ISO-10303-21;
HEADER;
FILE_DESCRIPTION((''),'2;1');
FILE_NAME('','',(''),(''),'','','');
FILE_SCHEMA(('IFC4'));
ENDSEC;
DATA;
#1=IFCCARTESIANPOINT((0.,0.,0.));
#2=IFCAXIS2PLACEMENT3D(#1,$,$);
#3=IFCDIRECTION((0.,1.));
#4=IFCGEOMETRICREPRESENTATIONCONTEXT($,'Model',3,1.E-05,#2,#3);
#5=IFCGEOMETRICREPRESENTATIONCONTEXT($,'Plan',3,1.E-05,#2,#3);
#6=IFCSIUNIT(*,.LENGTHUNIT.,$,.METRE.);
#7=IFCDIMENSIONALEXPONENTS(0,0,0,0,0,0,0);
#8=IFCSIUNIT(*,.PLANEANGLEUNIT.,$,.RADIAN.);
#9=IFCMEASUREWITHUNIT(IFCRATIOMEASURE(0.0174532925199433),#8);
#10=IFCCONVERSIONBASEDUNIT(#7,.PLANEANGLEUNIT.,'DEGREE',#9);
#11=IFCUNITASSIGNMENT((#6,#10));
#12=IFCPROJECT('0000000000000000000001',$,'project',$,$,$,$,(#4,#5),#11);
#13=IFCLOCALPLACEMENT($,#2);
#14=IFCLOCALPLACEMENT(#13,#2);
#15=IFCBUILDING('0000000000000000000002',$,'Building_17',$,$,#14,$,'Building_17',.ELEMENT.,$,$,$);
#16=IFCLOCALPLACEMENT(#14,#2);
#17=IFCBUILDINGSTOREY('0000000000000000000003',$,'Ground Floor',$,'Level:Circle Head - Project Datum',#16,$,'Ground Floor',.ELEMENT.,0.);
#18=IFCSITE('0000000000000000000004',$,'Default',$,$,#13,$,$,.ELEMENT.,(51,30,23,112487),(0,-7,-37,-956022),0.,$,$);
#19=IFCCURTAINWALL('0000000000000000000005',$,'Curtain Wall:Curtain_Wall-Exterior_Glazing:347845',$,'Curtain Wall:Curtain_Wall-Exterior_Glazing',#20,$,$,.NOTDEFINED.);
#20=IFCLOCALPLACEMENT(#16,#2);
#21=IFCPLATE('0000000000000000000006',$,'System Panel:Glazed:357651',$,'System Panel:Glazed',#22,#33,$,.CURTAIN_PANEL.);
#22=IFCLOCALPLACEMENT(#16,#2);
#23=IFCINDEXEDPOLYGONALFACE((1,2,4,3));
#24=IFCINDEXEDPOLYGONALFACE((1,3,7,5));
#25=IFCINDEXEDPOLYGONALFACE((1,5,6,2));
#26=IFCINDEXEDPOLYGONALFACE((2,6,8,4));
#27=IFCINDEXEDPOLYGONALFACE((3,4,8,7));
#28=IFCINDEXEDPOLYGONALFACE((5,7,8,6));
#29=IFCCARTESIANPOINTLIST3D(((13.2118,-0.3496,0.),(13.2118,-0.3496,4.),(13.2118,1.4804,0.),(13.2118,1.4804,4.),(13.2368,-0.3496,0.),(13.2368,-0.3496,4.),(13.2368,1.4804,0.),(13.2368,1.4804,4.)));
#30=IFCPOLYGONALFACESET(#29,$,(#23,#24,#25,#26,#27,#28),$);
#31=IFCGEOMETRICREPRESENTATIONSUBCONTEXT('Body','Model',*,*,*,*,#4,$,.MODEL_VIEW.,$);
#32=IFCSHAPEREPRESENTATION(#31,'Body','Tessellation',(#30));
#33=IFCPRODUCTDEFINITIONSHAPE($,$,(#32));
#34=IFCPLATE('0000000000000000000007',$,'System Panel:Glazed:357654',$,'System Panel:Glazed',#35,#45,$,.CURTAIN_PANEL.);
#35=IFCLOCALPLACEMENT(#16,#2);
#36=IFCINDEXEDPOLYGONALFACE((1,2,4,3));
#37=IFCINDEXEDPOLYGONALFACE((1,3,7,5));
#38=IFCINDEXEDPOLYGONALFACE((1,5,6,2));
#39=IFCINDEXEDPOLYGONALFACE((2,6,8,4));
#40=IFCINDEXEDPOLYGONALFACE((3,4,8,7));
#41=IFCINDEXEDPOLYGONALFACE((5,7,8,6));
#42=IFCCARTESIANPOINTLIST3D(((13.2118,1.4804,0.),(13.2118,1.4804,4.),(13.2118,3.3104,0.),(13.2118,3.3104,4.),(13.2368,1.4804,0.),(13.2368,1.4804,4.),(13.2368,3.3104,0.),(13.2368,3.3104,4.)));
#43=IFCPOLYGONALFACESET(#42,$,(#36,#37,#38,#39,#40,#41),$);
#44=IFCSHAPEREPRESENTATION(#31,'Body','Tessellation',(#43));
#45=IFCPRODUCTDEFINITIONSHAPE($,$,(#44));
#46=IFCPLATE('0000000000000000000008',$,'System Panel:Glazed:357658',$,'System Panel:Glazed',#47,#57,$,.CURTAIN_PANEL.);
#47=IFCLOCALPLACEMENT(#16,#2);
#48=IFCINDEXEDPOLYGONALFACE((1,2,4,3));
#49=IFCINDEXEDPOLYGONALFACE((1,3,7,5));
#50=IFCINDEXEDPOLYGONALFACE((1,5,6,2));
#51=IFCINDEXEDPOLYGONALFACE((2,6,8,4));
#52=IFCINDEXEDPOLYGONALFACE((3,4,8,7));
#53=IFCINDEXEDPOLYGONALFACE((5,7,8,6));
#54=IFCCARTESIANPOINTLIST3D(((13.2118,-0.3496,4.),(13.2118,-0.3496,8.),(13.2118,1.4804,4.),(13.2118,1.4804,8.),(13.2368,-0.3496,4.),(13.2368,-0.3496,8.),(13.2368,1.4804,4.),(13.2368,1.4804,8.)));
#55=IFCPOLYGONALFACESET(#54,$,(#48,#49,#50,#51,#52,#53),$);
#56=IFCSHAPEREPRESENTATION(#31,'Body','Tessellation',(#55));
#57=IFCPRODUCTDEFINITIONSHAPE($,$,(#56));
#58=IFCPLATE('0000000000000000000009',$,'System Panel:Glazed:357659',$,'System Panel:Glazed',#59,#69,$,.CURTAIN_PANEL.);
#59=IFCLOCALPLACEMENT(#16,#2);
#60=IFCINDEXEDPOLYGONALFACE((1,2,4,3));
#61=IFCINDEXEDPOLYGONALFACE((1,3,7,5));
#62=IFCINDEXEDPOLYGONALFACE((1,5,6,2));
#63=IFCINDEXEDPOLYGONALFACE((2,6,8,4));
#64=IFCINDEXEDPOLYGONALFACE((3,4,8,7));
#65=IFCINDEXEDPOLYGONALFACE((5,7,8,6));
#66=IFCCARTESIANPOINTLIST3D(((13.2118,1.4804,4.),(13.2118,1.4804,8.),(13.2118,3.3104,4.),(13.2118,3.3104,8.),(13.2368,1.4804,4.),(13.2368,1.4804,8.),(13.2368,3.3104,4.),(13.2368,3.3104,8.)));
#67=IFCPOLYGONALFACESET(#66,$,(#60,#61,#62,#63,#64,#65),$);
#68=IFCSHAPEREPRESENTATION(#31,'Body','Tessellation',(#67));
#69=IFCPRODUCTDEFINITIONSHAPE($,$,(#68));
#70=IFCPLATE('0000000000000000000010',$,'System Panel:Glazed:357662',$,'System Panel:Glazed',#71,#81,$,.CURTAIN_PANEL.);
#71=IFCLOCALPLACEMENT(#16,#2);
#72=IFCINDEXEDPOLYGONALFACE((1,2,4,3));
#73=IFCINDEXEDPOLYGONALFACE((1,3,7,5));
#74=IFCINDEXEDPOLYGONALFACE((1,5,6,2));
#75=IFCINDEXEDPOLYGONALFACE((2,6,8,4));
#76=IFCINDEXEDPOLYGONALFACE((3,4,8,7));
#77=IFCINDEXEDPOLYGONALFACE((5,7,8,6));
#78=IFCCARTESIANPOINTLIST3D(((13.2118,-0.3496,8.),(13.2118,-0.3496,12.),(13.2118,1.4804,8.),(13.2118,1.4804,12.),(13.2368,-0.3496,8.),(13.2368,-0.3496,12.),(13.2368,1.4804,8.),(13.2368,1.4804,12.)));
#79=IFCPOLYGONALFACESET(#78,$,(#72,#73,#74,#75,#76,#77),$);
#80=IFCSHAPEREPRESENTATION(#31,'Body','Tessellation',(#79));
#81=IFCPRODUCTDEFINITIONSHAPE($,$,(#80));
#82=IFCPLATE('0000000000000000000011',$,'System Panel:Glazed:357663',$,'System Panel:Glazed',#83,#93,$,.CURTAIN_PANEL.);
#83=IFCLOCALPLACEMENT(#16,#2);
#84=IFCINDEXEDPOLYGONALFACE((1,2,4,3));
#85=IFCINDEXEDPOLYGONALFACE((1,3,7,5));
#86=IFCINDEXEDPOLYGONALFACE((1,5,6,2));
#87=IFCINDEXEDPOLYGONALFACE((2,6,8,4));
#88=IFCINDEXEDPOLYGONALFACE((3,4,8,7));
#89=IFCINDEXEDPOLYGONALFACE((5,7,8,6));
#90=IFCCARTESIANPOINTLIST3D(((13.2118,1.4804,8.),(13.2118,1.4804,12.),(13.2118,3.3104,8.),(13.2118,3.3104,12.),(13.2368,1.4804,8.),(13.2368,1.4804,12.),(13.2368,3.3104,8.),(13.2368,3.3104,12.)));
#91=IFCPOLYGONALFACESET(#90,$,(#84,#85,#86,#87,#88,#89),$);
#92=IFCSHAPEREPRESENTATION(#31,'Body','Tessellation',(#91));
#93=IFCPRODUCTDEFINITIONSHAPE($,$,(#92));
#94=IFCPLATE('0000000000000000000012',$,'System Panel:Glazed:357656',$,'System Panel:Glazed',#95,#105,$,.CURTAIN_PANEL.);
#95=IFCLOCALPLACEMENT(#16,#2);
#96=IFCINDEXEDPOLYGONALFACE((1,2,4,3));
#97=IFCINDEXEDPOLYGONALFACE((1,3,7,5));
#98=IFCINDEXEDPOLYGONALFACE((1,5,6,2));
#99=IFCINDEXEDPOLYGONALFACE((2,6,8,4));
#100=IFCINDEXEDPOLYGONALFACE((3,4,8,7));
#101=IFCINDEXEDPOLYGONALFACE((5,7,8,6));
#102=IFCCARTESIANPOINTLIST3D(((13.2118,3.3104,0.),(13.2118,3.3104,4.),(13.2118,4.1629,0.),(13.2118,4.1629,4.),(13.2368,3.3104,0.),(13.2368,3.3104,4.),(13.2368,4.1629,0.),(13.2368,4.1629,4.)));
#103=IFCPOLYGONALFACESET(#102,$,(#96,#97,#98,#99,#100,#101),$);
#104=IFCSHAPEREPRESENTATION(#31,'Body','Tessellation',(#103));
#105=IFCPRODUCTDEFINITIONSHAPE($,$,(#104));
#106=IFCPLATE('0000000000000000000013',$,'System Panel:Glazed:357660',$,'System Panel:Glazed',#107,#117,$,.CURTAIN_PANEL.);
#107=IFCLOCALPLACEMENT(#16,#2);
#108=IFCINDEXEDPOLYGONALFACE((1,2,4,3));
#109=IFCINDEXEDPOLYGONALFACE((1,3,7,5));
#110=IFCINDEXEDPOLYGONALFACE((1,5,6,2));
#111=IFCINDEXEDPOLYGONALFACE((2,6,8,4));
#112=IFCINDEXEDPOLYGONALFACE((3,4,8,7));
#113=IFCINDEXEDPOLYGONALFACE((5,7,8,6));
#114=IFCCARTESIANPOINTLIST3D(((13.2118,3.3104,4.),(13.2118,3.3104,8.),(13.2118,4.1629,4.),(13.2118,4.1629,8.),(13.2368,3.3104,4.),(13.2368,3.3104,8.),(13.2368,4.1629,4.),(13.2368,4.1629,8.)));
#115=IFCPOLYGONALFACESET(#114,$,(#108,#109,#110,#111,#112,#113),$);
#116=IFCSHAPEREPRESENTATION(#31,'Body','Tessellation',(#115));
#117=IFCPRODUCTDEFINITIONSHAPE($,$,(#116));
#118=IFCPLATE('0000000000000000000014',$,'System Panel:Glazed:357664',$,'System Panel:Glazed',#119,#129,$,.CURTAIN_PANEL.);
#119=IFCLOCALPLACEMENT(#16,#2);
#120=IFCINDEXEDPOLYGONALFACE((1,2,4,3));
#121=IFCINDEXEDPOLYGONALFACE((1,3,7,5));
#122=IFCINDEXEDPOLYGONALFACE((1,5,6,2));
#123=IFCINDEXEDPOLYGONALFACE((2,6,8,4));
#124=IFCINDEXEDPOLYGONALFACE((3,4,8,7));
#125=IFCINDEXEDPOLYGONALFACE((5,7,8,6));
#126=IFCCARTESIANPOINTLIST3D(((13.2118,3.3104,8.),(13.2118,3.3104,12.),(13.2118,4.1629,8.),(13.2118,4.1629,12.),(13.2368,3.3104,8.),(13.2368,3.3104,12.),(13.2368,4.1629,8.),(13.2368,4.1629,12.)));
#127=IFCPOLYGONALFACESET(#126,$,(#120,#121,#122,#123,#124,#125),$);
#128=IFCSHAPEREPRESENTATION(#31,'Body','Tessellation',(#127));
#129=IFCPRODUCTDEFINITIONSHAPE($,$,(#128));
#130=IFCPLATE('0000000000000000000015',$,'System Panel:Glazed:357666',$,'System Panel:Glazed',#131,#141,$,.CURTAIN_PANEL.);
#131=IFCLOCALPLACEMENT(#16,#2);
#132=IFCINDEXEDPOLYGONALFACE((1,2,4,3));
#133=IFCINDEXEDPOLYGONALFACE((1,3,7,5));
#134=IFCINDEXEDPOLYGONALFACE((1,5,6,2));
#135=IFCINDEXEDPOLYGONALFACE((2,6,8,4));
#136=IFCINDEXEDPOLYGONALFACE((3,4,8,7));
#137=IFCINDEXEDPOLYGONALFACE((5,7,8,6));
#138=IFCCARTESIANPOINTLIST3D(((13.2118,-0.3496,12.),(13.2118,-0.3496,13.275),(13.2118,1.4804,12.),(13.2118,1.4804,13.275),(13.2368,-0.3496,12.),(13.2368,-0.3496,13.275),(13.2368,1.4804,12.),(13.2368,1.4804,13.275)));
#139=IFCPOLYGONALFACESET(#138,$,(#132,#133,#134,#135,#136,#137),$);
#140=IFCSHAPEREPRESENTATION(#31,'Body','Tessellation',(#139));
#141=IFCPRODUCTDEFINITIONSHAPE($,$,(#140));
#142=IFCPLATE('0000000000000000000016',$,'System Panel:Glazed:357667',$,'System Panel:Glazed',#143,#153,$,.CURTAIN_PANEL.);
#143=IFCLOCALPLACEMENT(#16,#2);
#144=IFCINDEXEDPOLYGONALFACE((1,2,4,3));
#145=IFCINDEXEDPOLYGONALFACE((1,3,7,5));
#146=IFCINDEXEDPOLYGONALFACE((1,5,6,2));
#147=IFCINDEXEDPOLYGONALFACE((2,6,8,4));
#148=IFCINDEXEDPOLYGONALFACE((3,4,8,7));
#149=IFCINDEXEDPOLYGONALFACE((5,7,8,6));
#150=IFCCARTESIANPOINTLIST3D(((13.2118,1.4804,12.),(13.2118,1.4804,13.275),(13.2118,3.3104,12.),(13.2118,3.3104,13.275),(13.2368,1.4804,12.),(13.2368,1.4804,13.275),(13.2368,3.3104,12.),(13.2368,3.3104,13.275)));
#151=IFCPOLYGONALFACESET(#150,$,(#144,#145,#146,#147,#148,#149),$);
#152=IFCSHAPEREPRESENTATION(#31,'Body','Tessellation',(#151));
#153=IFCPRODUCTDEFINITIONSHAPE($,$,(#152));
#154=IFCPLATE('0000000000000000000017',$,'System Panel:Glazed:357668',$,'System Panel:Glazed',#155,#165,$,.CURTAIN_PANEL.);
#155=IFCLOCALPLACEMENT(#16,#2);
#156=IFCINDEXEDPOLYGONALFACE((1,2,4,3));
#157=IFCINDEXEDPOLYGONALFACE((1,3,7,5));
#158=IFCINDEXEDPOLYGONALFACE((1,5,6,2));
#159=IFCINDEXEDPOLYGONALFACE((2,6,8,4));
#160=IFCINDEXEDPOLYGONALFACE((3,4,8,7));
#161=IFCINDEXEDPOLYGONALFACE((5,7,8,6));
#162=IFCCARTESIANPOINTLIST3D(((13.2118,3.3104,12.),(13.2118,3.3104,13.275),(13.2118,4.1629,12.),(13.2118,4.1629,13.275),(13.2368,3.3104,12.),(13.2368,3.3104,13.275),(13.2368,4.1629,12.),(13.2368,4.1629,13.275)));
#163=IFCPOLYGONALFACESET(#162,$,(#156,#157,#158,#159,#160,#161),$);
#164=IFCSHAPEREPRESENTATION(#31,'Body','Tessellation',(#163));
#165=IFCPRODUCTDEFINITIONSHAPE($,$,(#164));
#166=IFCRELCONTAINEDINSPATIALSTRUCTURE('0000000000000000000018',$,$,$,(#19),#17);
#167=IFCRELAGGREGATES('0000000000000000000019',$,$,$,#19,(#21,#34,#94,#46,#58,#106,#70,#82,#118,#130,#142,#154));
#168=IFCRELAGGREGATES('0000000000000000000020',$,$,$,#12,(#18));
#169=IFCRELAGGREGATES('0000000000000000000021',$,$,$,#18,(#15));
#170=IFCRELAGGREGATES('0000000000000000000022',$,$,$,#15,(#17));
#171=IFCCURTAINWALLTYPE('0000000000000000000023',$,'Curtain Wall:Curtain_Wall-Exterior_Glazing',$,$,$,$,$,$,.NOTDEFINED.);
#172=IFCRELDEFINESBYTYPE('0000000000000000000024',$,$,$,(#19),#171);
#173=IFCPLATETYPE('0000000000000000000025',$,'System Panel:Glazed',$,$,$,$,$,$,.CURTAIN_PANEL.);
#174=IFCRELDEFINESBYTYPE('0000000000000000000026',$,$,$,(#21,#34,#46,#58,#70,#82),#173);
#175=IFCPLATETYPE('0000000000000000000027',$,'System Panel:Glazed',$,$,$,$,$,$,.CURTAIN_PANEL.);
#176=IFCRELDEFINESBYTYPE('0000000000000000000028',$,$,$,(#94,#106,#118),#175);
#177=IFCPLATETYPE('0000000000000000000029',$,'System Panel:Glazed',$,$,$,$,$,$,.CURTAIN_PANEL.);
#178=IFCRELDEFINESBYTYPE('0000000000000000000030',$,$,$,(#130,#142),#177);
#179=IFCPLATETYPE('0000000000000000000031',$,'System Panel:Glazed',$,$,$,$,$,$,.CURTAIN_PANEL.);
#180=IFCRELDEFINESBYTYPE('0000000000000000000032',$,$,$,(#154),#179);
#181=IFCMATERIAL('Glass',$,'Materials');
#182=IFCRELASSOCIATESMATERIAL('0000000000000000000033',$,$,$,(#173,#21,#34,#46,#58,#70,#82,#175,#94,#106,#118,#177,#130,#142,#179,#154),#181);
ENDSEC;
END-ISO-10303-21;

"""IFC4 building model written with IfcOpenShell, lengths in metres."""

from ifc_helpers import new_model, entity, si_unit, converted_unit, direction, frame, origin, place, context, subcontext, project, spatial, indexed_curve, outline, extrude, source, transform, mapped, material, type_object, type_shapes, element, aggregate, save


model = new_model("IFC4")

# Units and contexts
model_context = context("Model", 3, precision=1e-05, world=origin(), true_north=direction((0.0, 1.0)))
plan_context = context("Plan", 3, precision=1e-05, world=origin(), true_north=direction((0.0, 1.0)))
body_context = subcontext(model_context, "Body", "Model", "MODEL_VIEW")
ifc_project = project(units=[si_unit("LENGTHUNIT", "METRE"), converted_unit("PLANEANGLEUNIT", "DEGREE", entity("IfcRatioMeasure", 0.0174532925199433), si_unit("PLANEANGLEUNIT", "RADIAN"), dimensions=[0, 0, 0, 0, 0, 0, 0])], contexts=[model_context, plan_context])

# Site, building, storey
site_placement = place(None, origin())
site = spatial("IfcSite", under=ifc_project, at=site_placement, Name="Default", CompositionType="ELEMENT", RefLatitude=(51, 30, 23, 112487), RefLongitude=(0, -7, -37, -956022), RefElevation=0.0)
building_placement = place(site_placement, origin())
building = spatial("IfcBuilding", under=site, at=building_placement, Name="Building_17", LongName="Building_17", CompositionType="ELEMENT")
storey_placement = place(building_placement, origin())
storey = spatial("IfcBuildingStorey", under=building, at=storey_placement, Name="Ground Floor", ObjectType="Level:Circle Head - Project Datum", LongName="Ground Floor", CompositionType="ELEMENT", Elevation=0.0)

# Curtain wall, plates
curtain_wall_type = type_object("IfcCurtainWallType", Name="Curtain Wall:Curtain_Wall-Exterior_Glazing", PredefinedType="NOTDEFINED")
curtain_wall_placement = place(storey_placement, origin())
curtain_wall = element("IfcCurtainWall", 1, at=curtain_wall_placement, inside=storey, type_object=curtain_wall_type, Name="Curtain Wall:Curtain_Wall-Exterior_Glazing:347845", ObjectType="Curtain Wall:Curtain_Wall-Exterior_Glazing", PredefinedType="NOTDEFINED")
ifc_material_1 = material(Name="Glass", Category="Materials")
plate_type_1 = type_object("IfcPlateType", Name="System Panel:Glazed", PredefinedType="CURTAIN_PANEL", material=ifc_material_1)
shared_shape_1 = source(origin(), body_context, "Body", "SweptSolid", [
    extrude(outline(indexed_curve([(-0.0125, -0.915), (0.0125, -0.915), (0.0125, 0.915), (-0.0125, 0.915), (-0.0125, -0.915)], self_intersect=False)), frame((0.0, 0.037, 0.0), z_axis=(0.0, 0.0, 1.0), x_axis=(0.0, 1.0, 0.0)), (0.0, 0.0, 1.0), 4.0),
])
type_shapes(plate_type_1, [shared_shape_1])
plate_1_placement = place(curtain_wall_placement, frame((13.2613, 0.5654, 0.0), z_axis=(0.0, 0.0, 1.0), x_axis=(0.0, 1.0, 0.0)))
plate_1 = element("IfcPlate", 2, at=plate_1_placement, type_object=plate_type_1, material=ifc_material_1, Name="System Panel:Glazed:357651", ObjectType="System Panel:Glazed", PredefinedType="CURTAIN_PANEL", context=body_context, shape_type="MappedRepresentation", body=[
    mapped(shared_shape_1, transform((0.0, 0.0, 0.0), scale=1.0)),
])
plate_2_placement = place(curtain_wall_placement, frame((13.2613, 2.3954, 0.0), z_axis=(0.0, 0.0, 1.0), x_axis=(0.0, 1.0, 0.0)))
plate_2 = element("IfcPlate", 3, at=plate_2_placement, type_object=plate_type_1, material=ifc_material_1, Name="System Panel:Glazed:357654", ObjectType="System Panel:Glazed", PredefinedType="CURTAIN_PANEL", context=body_context, shape_type="MappedRepresentation", body=[
    mapped(shared_shape_1, transform((0.0, 0.0, 0.0), scale=1.0)),
])
plate_3_placement = place(curtain_wall_placement, frame((13.2613, 0.5654, 4.0), z_axis=(0.0, 0.0, 1.0), x_axis=(0.0, 1.0, 0.0)))
plate_3 = element("IfcPlate", 4, at=plate_3_placement, type_object=plate_type_1, material=ifc_material_1, Name="System Panel:Glazed:357658", ObjectType="System Panel:Glazed", PredefinedType="CURTAIN_PANEL", context=body_context, shape_type="MappedRepresentation", body=[
    mapped(shared_shape_1, transform((0.0, 0.0, 0.0), scale=1.0)),
])
plate_4_placement = place(curtain_wall_placement, frame((13.2613, 2.3954, 4.0), z_axis=(0.0, 0.0, 1.0), x_axis=(0.0, 1.0, 0.0)))
plate_4 = element("IfcPlate", 5, at=plate_4_placement, type_object=plate_type_1, material=ifc_material_1, Name="System Panel:Glazed:357659", ObjectType="System Panel:Glazed", PredefinedType="CURTAIN_PANEL", context=body_context, shape_type="MappedRepresentation", body=[
    mapped(shared_shape_1, transform((0.0, 0.0, 0.0), scale=1.0)),
])
plate_5_placement = place(curtain_wall_placement, frame((13.2613, 0.5654, 8.0), z_axis=(0.0, 0.0, 1.0), x_axis=(0.0, 1.0, 0.0)))
plate_5 = element("IfcPlate", 6, at=plate_5_placement, type_object=plate_type_1, material=ifc_material_1, Name="System Panel:Glazed:357662", ObjectType="System Panel:Glazed", PredefinedType="CURTAIN_PANEL", context=body_context, shape_type="MappedRepresentation", body=[
    mapped(shared_shape_1, transform((0.0, 0.0, 0.0), scale=1.0)),
])
plate_6_placement = place(curtain_wall_placement, frame((13.2613, 2.3954, 8.0), z_axis=(0.0, 0.0, 1.0), x_axis=(0.0, 1.0, 0.0)))
plate_6 = element("IfcPlate", 7, at=plate_6_placement, type_object=plate_type_1, material=ifc_material_1, Name="System Panel:Glazed:357663", ObjectType="System Panel:Glazed", PredefinedType="CURTAIN_PANEL", context=body_context, shape_type="MappedRepresentation", body=[
    mapped(shared_shape_1, transform((0.0, 0.0, 0.0), scale=1.0)),
])
plate_type_2 = type_object("IfcPlateType", Name="System Panel:Glazed", PredefinedType="CURTAIN_PANEL", material=ifc_material_1)
shared_shape_2 = source(origin(), body_context, "Body", "SweptSolid", [
    extrude(outline(indexed_curve([(-0.0125, -0.4262), (0.0125, -0.4262), (0.0125, 0.4262), (-0.0125, 0.4262), (-0.0125, -0.4262)], self_intersect=False)), frame((0.0, 0.037, 0.0), z_axis=(0.0, 0.0, 1.0), x_axis=(0.0, 1.0, 0.0)), (0.0, 0.0, 1.0), 4.0),
])
type_shapes(plate_type_2, [shared_shape_2])
plate_7_placement = place(curtain_wall_placement, frame((13.2613, 3.7366, 0.0), z_axis=(0.0, 0.0, 1.0), x_axis=(0.0, 1.0, 0.0)))
plate_7 = element("IfcPlate", 8, at=plate_7_placement, type_object=plate_type_2, material=ifc_material_1, Name="System Panel:Glazed:357656", ObjectType="System Panel:Glazed", PredefinedType="CURTAIN_PANEL", context=body_context, shape_type="MappedRepresentation", body=[
    mapped(shared_shape_2, transform((0.0, 0.0, 0.0), scale=1.0)),
])
plate_8_placement = place(curtain_wall_placement, frame((13.2613, 3.7366, 4.0), z_axis=(0.0, 0.0, 1.0), x_axis=(0.0, 1.0, 0.0)))
plate_8 = element("IfcPlate", 9, at=plate_8_placement, type_object=plate_type_2, material=ifc_material_1, Name="System Panel:Glazed:357660", ObjectType="System Panel:Glazed", PredefinedType="CURTAIN_PANEL", context=body_context, shape_type="MappedRepresentation", body=[
    mapped(shared_shape_2, transform((0.0, 0.0, 0.0), scale=1.0)),
])
plate_9_placement = place(curtain_wall_placement, frame((13.2613, 3.7366, 8.0), z_axis=(0.0, 0.0, 1.0), x_axis=(0.0, 1.0, 0.0)))
plate_9 = element("IfcPlate", 10, at=plate_9_placement, type_object=plate_type_2, material=ifc_material_1, Name="System Panel:Glazed:357664", ObjectType="System Panel:Glazed", PredefinedType="CURTAIN_PANEL", context=body_context, shape_type="MappedRepresentation", body=[
    mapped(shared_shape_2, transform((0.0, 0.0, 0.0), scale=1.0)),
])
plate_type_3 = type_object("IfcPlateType", Name="System Panel:Glazed", PredefinedType="CURTAIN_PANEL", material=ifc_material_1)
shared_shape_3 = source(origin(), body_context, "Body", "SweptSolid", [
    extrude(outline(indexed_curve([(-0.0125, -0.915), (0.0125, -0.915), (0.0125, 0.915), (-0.0125, 0.915), (-0.0125, -0.915)], self_intersect=False)), frame((0.0, 0.037, 0.0), z_axis=(0.0, 0.0, 1.0), x_axis=(0.0, 1.0, 0.0)), (0.0, 0.0, 1.0), 1.275),
])
type_shapes(plate_type_3, [shared_shape_3])
plate_10_placement = place(curtain_wall_placement, frame((13.2613, 0.5654, 12.0), z_axis=(0.0, 0.0, 1.0), x_axis=(0.0, 1.0, 0.0)))
plate_10 = element("IfcPlate", 11, at=plate_10_placement, type_object=plate_type_3, material=ifc_material_1, Name="System Panel:Glazed:357666", ObjectType="System Panel:Glazed", PredefinedType="CURTAIN_PANEL", context=body_context, shape_type="MappedRepresentation", body=[
    mapped(shared_shape_3, transform((0.0, 0.0, 0.0), scale=1.0)),
])
plate_11_placement = place(curtain_wall_placement, frame((13.2613, 2.3954, 12.0), z_axis=(0.0, 0.0, 1.0), x_axis=(0.0, 1.0, 0.0)))
plate_11 = element("IfcPlate", 12, at=plate_11_placement, type_object=plate_type_3, material=ifc_material_1, Name="System Panel:Glazed:357667", ObjectType="System Panel:Glazed", PredefinedType="CURTAIN_PANEL", context=body_context, shape_type="MappedRepresentation", body=[
    mapped(shared_shape_3, transform((0.0, 0.0, 0.0), scale=1.0)),
])
plate_type_4 = type_object("IfcPlateType", Name="System Panel:Glazed", PredefinedType="CURTAIN_PANEL", material=ifc_material_1)
shared_shape_4 = source(origin(), body_context, "Body", "SweptSolid", [
    extrude(outline(indexed_curve([(-0.0125, -0.4262), (0.0125, -0.4262), (0.0125, 0.4262), (-0.0125, 0.4262), (-0.0125, -0.4262)], self_intersect=False)), frame((0.0, 0.037, 0.0), z_axis=(0.0, 0.0, 1.0), x_axis=(0.0, 1.0, 0.0)), (0.0, 0.0, 1.0), 1.275),
])
type_shapes(plate_type_4, [shared_shape_4])
plate_12_placement = place(curtain_wall_placement, frame((13.2613, 3.7366, 12.0), z_axis=(0.0, 0.0, 1.0), x_axis=(0.0, 1.0, 0.0)))
plate_12 = element("IfcPlate", 13, at=plate_12_placement, type_object=plate_type_4, material=ifc_material_1, Name="System Panel:Glazed:357668", ObjectType="System Panel:Glazed", PredefinedType="CURTAIN_PANEL", context=body_context, shape_type="MappedRepresentation", body=[
    mapped(shared_shape_4, transform((0.0, 0.0, 0.0), scale=1.0)),
])
aggregate(curtain_wall, [plate_1, plate_2, plate_7, plate_3, plate_4, plate_8, plate_5, plate_6, plate_9, plate_10, plate_11, plate_12])

save(model, "model.ifc")
